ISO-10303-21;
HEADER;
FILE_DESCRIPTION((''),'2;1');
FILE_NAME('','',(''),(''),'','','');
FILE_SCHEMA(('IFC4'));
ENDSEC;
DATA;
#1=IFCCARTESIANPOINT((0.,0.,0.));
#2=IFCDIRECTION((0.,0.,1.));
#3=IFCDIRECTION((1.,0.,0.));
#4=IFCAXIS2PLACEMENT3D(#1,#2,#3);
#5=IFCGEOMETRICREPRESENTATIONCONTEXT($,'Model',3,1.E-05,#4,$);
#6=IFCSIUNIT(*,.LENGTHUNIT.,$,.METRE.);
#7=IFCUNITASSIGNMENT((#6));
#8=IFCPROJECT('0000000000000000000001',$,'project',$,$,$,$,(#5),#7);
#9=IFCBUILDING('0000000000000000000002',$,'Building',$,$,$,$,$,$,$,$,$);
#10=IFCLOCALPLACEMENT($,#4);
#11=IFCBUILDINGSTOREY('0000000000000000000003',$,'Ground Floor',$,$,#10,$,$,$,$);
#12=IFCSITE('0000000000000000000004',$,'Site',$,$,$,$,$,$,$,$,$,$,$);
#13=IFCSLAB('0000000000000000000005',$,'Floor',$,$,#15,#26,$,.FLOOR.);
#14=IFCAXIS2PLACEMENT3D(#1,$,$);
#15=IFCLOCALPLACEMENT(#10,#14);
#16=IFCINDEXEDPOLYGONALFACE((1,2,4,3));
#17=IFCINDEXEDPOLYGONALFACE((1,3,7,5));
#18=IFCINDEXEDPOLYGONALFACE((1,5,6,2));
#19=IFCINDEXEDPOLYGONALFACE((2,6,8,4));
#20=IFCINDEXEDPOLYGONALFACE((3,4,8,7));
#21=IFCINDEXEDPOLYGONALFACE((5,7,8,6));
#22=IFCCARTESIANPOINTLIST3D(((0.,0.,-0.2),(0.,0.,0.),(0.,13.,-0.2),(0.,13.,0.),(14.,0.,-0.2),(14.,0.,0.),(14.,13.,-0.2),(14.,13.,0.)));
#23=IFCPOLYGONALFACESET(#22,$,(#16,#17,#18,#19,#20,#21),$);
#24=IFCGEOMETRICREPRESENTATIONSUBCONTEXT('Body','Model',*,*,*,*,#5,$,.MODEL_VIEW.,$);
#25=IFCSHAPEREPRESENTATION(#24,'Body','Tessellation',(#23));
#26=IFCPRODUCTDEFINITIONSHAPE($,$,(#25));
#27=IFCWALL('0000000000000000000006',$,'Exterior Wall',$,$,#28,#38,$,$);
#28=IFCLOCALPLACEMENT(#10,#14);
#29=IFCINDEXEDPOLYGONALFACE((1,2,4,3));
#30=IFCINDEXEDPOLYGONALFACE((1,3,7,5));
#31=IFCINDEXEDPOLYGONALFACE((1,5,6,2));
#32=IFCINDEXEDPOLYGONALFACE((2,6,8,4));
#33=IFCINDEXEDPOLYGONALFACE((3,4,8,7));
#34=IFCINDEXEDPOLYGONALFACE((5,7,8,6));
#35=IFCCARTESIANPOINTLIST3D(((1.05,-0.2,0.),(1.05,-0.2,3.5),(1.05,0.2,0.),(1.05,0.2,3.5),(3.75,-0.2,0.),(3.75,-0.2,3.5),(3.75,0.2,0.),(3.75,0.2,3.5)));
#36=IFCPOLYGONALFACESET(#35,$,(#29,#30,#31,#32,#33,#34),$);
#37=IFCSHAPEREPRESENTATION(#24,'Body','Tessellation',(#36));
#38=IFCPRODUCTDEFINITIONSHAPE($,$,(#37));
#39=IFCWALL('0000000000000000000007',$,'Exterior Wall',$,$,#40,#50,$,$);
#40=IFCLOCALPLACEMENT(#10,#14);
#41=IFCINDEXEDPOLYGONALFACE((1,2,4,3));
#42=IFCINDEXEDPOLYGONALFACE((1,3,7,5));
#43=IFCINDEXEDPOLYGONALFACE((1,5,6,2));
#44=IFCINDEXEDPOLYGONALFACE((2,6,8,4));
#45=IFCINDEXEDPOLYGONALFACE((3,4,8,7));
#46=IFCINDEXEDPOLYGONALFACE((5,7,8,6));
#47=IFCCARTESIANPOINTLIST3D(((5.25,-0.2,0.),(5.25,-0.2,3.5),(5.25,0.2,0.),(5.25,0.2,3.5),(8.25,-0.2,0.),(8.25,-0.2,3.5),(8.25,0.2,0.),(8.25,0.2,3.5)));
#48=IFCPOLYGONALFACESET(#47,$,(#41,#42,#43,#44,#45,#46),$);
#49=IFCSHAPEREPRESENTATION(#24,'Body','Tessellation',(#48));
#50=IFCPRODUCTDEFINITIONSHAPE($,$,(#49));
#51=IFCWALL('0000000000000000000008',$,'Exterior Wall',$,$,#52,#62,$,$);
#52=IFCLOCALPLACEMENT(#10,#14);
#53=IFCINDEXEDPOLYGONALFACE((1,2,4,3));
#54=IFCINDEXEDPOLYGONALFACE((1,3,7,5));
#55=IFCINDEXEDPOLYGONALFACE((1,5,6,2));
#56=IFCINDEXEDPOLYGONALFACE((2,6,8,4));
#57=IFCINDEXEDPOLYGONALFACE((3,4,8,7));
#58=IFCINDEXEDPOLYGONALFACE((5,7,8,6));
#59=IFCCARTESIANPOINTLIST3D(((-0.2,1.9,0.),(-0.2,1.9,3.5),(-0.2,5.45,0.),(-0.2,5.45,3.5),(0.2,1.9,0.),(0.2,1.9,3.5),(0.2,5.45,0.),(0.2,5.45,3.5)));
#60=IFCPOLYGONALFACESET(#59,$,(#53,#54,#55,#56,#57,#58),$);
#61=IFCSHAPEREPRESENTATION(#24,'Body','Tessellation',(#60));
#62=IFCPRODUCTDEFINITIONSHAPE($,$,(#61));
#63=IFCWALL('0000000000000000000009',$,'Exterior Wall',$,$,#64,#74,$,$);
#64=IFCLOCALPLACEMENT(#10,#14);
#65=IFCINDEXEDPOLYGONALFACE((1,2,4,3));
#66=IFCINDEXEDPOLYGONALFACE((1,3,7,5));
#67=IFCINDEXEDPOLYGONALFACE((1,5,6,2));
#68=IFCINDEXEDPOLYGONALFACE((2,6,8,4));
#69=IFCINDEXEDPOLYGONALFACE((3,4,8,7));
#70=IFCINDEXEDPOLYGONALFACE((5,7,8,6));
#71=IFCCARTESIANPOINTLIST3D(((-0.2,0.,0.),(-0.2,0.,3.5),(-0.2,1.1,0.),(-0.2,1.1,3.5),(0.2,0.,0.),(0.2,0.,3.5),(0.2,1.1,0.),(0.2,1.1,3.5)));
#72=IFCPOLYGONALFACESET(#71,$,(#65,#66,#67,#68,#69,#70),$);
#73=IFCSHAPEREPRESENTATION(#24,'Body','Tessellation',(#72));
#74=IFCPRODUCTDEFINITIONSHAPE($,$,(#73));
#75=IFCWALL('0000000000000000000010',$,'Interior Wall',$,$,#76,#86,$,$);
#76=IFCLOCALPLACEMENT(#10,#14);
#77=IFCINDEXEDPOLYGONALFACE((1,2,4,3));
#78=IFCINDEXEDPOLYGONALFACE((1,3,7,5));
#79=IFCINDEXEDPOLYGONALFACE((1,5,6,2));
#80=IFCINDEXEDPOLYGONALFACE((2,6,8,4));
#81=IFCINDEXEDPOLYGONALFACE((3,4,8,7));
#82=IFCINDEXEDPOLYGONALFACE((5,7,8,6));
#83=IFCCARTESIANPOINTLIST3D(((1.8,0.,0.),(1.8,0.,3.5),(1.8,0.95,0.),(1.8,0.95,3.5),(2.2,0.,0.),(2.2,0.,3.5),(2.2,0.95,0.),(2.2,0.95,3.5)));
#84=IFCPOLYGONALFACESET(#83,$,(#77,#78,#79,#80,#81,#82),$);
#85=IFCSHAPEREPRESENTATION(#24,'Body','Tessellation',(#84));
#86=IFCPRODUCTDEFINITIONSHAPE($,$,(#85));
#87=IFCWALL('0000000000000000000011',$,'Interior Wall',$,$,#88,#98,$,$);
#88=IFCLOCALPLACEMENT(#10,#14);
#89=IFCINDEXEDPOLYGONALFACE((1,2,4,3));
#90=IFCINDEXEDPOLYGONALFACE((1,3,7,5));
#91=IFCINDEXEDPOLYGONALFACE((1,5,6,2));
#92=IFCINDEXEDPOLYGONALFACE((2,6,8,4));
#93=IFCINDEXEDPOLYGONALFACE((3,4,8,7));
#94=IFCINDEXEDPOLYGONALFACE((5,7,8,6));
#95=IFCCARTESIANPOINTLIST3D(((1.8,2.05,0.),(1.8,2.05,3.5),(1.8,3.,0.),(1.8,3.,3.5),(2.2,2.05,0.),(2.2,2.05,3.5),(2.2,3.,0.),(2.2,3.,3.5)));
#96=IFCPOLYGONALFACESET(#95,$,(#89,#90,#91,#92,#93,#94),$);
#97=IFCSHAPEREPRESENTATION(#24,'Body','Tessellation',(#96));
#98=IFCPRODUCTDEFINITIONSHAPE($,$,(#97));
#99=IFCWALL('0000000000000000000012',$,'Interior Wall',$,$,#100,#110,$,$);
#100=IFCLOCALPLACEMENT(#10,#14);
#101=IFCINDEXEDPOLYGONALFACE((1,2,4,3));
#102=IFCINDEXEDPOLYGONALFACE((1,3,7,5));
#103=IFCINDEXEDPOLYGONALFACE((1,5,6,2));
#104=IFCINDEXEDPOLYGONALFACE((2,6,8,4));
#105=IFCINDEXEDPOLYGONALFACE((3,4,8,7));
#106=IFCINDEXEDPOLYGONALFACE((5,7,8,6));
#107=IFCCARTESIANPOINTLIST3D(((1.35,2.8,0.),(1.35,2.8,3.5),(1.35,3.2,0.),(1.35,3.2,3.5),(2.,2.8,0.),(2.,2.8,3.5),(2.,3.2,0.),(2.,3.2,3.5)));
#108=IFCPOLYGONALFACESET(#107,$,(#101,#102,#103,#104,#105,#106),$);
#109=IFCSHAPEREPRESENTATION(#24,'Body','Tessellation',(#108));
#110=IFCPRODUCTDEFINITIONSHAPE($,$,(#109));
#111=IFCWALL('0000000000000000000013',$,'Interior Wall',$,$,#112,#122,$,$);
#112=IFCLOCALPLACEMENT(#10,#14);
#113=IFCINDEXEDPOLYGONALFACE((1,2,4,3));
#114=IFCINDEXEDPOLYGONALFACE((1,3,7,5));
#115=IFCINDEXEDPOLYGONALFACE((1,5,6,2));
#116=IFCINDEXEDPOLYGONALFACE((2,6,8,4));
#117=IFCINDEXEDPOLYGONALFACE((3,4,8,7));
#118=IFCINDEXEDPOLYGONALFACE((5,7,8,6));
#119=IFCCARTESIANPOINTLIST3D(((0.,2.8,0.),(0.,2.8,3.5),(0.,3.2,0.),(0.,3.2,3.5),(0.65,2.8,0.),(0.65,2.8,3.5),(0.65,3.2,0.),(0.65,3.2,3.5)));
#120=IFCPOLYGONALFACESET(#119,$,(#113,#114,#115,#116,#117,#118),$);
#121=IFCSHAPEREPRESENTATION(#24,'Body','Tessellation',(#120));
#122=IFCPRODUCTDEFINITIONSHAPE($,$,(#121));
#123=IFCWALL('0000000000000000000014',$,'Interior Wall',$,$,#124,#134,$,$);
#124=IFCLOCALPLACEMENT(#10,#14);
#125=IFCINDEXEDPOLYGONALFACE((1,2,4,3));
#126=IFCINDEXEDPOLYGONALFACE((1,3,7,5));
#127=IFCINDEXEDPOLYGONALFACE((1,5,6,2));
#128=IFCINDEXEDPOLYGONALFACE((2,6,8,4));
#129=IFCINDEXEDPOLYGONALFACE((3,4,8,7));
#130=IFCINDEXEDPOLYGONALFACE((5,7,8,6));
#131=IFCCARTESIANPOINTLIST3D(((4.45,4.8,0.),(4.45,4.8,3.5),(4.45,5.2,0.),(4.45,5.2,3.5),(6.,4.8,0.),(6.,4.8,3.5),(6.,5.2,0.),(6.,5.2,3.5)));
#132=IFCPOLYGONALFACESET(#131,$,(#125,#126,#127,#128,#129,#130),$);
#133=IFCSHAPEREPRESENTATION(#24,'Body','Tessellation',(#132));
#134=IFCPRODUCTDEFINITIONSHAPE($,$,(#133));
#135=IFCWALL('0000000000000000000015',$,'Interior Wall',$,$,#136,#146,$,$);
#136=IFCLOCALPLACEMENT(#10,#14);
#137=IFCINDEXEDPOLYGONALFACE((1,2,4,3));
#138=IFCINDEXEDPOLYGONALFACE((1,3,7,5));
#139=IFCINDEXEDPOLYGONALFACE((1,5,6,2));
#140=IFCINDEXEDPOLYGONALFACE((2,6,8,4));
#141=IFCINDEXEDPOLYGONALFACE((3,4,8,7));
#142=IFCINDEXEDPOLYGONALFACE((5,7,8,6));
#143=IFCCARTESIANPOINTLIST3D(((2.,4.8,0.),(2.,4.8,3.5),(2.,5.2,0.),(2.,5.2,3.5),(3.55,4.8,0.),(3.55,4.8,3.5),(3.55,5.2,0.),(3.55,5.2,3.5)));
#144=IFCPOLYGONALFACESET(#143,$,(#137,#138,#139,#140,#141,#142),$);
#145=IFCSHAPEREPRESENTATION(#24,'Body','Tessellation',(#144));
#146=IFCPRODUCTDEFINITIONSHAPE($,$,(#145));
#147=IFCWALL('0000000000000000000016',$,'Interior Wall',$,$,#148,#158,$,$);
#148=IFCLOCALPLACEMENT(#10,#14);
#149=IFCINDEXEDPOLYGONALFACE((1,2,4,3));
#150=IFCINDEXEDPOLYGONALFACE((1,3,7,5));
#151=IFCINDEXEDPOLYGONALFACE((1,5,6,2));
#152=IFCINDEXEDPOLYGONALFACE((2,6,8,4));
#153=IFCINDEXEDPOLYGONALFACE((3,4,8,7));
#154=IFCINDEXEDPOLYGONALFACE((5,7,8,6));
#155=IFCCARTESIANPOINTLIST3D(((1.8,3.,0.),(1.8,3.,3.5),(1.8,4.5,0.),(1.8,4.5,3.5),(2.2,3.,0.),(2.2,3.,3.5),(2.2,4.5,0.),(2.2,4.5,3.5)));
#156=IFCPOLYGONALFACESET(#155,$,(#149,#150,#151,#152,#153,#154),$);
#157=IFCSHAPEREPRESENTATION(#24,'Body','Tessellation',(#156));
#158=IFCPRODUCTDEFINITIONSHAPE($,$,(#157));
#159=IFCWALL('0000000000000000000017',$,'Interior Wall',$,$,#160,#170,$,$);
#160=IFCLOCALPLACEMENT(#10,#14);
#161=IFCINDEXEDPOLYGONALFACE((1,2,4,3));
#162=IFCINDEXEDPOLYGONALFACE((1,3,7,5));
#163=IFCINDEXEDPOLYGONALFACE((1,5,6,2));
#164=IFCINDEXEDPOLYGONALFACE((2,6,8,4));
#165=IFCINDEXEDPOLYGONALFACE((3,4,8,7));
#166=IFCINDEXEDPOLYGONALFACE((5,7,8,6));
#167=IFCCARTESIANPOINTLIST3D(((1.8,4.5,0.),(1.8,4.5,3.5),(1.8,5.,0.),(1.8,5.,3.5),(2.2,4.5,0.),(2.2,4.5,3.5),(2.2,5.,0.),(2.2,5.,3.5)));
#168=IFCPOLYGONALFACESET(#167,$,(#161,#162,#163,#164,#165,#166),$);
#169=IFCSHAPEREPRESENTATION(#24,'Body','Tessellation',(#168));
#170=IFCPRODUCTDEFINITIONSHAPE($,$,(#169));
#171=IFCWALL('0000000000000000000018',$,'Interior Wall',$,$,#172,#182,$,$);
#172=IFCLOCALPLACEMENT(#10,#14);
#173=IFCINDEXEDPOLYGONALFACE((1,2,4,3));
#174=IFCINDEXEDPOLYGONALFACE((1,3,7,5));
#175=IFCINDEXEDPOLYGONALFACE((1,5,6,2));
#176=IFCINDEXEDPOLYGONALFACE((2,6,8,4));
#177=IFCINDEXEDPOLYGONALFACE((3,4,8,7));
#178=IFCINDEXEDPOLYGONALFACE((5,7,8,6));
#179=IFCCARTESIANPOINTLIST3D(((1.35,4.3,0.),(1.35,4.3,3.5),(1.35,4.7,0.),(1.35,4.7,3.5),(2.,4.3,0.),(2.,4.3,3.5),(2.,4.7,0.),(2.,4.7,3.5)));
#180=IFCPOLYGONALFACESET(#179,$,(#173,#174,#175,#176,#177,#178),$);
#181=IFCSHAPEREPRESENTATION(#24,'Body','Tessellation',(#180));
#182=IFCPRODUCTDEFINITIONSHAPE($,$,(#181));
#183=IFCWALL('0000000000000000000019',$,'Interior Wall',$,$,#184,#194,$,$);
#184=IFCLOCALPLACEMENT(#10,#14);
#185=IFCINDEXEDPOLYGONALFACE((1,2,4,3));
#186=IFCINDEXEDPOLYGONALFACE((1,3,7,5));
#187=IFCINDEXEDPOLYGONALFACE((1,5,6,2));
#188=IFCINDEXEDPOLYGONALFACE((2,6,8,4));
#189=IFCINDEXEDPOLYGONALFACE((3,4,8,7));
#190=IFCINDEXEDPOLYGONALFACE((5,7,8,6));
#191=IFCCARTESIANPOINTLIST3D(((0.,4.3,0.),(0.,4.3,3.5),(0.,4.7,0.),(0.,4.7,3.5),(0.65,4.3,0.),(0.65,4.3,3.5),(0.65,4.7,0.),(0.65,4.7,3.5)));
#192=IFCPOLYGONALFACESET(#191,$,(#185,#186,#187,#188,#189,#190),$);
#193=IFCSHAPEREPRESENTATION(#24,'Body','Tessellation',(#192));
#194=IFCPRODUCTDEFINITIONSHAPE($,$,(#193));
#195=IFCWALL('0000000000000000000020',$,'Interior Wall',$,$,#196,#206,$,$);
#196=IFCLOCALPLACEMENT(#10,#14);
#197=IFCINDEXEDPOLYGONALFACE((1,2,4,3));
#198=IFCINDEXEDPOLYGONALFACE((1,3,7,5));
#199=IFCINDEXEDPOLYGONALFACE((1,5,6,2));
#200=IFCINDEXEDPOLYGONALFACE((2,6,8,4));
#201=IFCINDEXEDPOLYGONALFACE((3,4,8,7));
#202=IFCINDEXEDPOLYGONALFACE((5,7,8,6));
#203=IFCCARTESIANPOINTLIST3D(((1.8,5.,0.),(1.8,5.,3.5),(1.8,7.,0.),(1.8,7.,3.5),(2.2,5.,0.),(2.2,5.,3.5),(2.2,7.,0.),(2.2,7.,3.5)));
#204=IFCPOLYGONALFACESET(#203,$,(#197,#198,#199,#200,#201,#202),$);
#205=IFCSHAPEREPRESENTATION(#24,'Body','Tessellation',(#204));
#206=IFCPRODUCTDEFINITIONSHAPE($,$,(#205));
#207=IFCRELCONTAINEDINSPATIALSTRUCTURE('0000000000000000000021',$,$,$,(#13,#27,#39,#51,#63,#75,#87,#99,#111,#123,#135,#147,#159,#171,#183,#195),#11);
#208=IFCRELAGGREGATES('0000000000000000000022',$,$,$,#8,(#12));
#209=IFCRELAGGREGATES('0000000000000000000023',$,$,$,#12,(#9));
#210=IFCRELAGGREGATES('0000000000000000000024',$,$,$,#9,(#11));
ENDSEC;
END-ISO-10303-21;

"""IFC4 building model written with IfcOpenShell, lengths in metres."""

from ifc_helpers import new_model, si_unit, frame, origin_with_axes, place, context, subcontext, project, spatial, indexed_curve, outline, extrude, element, save


model = new_model("IFC4")

# Units and contexts
model_context = context("Model", 3, precision=1e-05, world=origin_with_axes())
body_context = subcontext(model_context, "Body", "Model", "MODEL_VIEW")
ifc_project = project(units=[si_unit("LENGTHUNIT", "METRE")], contexts=[model_context])

# Site, building, storey
site = spatial("IfcSite", under=ifc_project, Name="Site")
building = spatial("IfcBuilding", under=site, Name="Building")
storey_placement = place(None, origin_with_axes())
storey = spatial("IfcBuildingStorey", under=building, at=storey_placement, Name="Ground Floor")

# Slab
slab_placement = place(storey_placement, frame((0.0, 0.0, -0.2), z_axis=(0.0, 0.0, 1.0), x_axis=(1.0, 0.0, 0.0)))
element("IfcSlab", 1, at=slab_placement, inside=storey, Name="Floor", PredefinedType="FLOOR", context=body_context, shape_type="SweptSolid", body=[
    extrude(outline(indexed_curve([(0.0, 0.0), (14.0, 0.0), (14.0, 13.0), (0.0, 13.0)])), None, (0.0, 0.0, 1.0), 0.2),
])

# Walls
wall_1_placement = place(storey_placement, frame((1.05, 0.0, 0.0), z_axis=(0.0, 0.0, 1.0), x_axis=(1.0, 0.0, 0.0)))
element("IfcWall", 2, at=wall_1_placement, inside=storey, Name="Exterior Wall", context=body_context, shape_type="SweptSolid", body=[
    extrude(outline(indexed_curve([(0.0, 0.0), (0.0, 0.4), (2.7, 0.4), (2.7, 0.0), (0.0, 0.0)], self_intersect=False)), frame((0.0, -0.2, 0.0), z_axis=(0.0, 0.0, 1.0), x_axis=(1.0, 0.0, 0.0)), (0.0, 0.0, 1.0), 3.5),
])
wall_2_placement = place(storey_placement, frame((5.25, 0.0, 0.0), z_axis=(0.0, 0.0, 1.0), x_axis=(1.0, 0.0, 0.0)))
element("IfcWall", 3, at=wall_2_placement, inside=storey, Name="Exterior Wall", context=body_context, shape_type="SweptSolid", body=[
    extrude(outline(indexed_curve([(0.0, 0.0), (0.0, 0.4), (3.0, 0.4), (3.0, 0.0), (0.0, 0.0)], self_intersect=False)), frame((0.0, -0.2, 0.0), z_axis=(0.0, 0.0, 1.0), x_axis=(1.0, 0.0, 0.0)), (0.0, 0.0, 1.0), 3.5),
])
wall_3_placement = place(storey_placement, frame((0.0, 5.45, 0.0), z_axis=(0.0, 0.0, 1.0), x_axis=(0.0, -1.0, 0.0)))
element("IfcWall", 4, at=wall_3_placement, inside=storey, Name="Exterior Wall", context=body_context, shape_type="SweptSolid", body=[
    extrude(outline(indexed_curve([(0.0, 0.0), (0.0, 0.4), (3.55, 0.4), (3.55, 0.0), (0.0, 0.0)], self_intersect=False)), frame((0.0, -0.2, 0.0), z_axis=(0.0, 0.0, 1.0), x_axis=(1.0, 0.0, 0.0)), (0.0, 0.0, 1.0), 3.5),
])
wall_4_placement = place(storey_placement, frame((0.0, 1.1, 0.0), z_axis=(0.0, 0.0, 1.0), x_axis=(0.0, -1.0, 0.0)))
element("IfcWall", 5, at=wall_4_placement, inside=storey, Name="Exterior Wall", context=body_context, shape_type="SweptSolid", body=[
    extrude(outline(indexed_curve([(0.0, 0.0), (0.0, 0.4), (1.1, 0.4), (1.1, 0.0), (0.0, 0.0)], self_intersect=False)), frame((0.0, -0.2, 0.0), z_axis=(0.0, 0.0, 1.0), x_axis=(1.0, 0.0, 0.0)), (0.0, 0.0, 1.0), 3.5),
])
wall_5_placement = place(storey_placement, frame((2.0, 0.0, 0.0), z_axis=(0.0, 0.0, 1.0), x_axis=(0.0, 1.0, 0.0)))
element("IfcWall", 6, at=wall_5_placement, inside=storey, Name="Interior Wall", context=body_context, shape_type="SweptSolid", body=[
    extrude(outline(indexed_curve([(0.0, 0.0), (0.0, 0.4), (0.95, 0.4), (0.95, 0.0), (0.0, 0.0)], self_intersect=False)), frame((0.0, -0.2, 0.0), z_axis=(0.0, 0.0, 1.0), x_axis=(1.0, 0.0, 0.0)), (0.0, 0.0, 1.0), 3.5),
])
wall_6_placement = place(storey_placement, frame((2.0, 2.05, 0.0), z_axis=(0.0, 0.0, 1.0), x_axis=(0.0, 1.0, 0.0)))
element("IfcWall", 7, at=wall_6_placement, inside=storey, Name="Interior Wall", context=body_context, shape_type="SweptSolid", body=[
    extrude(outline(indexed_curve([(0.0, 0.0), (0.0, 0.4), (0.95, 0.4), (0.95, 0.0), (0.0, 0.0)], self_intersect=False)), frame((0.0, -0.2, 0.0), z_axis=(0.0, 0.0, 1.0), x_axis=(1.0, 0.0, 0.0)), (0.0, 0.0, 1.0), 3.5),
])
for number, where, z_axis, x_axis, name in (
    (8, (2.0, 3.0, 0.0), (0.0, 0.0, 1.0), (-1.0, 0.0, 0.0), "Interior Wall"),
    (9, (0.65, 3.0, 0.0), (0.0, 0.0, 1.0), (-1.0, 0.0, 0.0), "Interior Wall"),
):
    element("IfcWall", number, at=place(storey_placement, frame(where, z_axis=z_axis, x_axis=x_axis)), inside=storey, Name=name, context=body_context, shape_type="SweptSolid", body=[
        extrude(outline(indexed_curve([(0.0, 0.0), (0.0, 0.4), (0.65, 0.4), (0.65, 0.0), (0.0, 0.0)], self_intersect=False)), frame((0.0, -0.2, 0.0), z_axis=(0.0, 0.0, 1.0), x_axis=(1.0, 0.0, 0.0)), (0.0, 0.0, 1.0), 3.5),
    ])
for number, where, z_axis, x_axis, name in (
    (10, (6.0, 5.0, 0.0), (0.0, 0.0, 1.0), (-1.0, 0.0, 0.0), "Interior Wall"),
    (11, (3.55, 5.0, 0.0), (0.0, 0.0, 1.0), (-1.0, 0.0, 0.0), "Interior Wall"),
):
    element("IfcWall", number, at=place(storey_placement, frame(where, z_axis=z_axis, x_axis=x_axis)), inside=storey, Name=name, context=body_context, shape_type="SweptSolid", body=[
        extrude(outline(indexed_curve([(0.0, 0.0), (0.0, 0.4), (1.55, 0.4), (1.55, 0.0), (0.0, 0.0)], self_intersect=False)), frame((0.0, -0.2, 0.0), z_axis=(0.0, 0.0, 1.0), x_axis=(1.0, 0.0, 0.0)), (0.0, 0.0, 1.0), 3.5),
    ])
wall_7_placement = place(storey_placement, frame((2.0, 4.5, 0.0), z_axis=(0.0, 0.0, 1.0), x_axis=(0.0, -1.0, 0.0)))
element("IfcWall", 12, at=wall_7_placement, inside=storey, Name="Interior Wall", context=body_context, shape_type="SweptSolid", body=[
    extrude(outline(indexed_curve([(0.0, 0.0), (0.0, 0.4), (1.5, 0.4), (1.5, 0.0), (0.0, 0.0)], self_intersect=False)), frame((0.0, -0.2, 0.0), z_axis=(0.0, 0.0, 1.0), x_axis=(1.0, 0.0, 0.0)), (0.0, 0.0, 1.0), 3.5),
])
wall_8_placement = place(storey_placement, frame((2.0, 5.0, 0.0), z_axis=(0.0, 0.0, 1.0), x_axis=(0.0, -1.0, 0.0)))
element("IfcWall", 13, at=wall_8_placement, inside=storey, Name="Interior Wall", context=body_context, shape_type="SweptSolid", body=[
    extrude(outline(indexed_curve([(0.0, 0.0), (0.0, 0.4), (0.5, 0.4), (0.5, 0.0), (0.0, 0.0)], self_intersect=False)), frame((0.0, -0.2, 0.0), z_axis=(0.0, 0.0, 1.0), x_axis=(1.0, 0.0, 0.0)), (0.0, 0.0, 1.0), 3.5),
])
for number, where, z_axis, x_axis, name in (
    (14, (2.0, 4.5, 0.0), (0.0, 0.0, 1.0), (-1.0, 0.0, 0.0), "Interior Wall"),
    (15, (0.65, 4.5, 0.0), (0.0, 0.0, 1.0), (-1.0, 0.0, 0.0), "Interior Wall"),
):
    element("IfcWall", number, at=place(storey_placement, frame(where, z_axis=z_axis, x_axis=x_axis)), inside=storey, Name=name, context=body_context, shape_type="SweptSolid", body=[
        extrude(outline(indexed_curve([(0.0, 0.0), (0.0, 0.4), (0.65, 0.4), (0.65, 0.0), (0.0, 0.0)], self_intersect=False)), frame((0.0, -0.2, 0.0), z_axis=(0.0, 0.0, 1.0), x_axis=(1.0, 0.0, 0.0)), (0.0, 0.0, 1.0), 3.5),
    ])
wall_9_placement = place(storey_placement, frame((2.0, 5.0, 0.0), z_axis=(0.0, 0.0, 1.0), x_axis=(0.0, 1.0, 0.0)))
element("IfcWall", 16, at=wall_9_placement, inside=storey, Name="Interior Wall", context=body_context, shape_type="SweptSolid", body=[
    extrude(outline(indexed_curve([(0.0, 0.0), (0.0, 0.4), (2.0, 0.4), (2.0, 0.0), (0.0, 0.0)], self_intersect=False)), frame((0.0, -0.2, 0.0), z_axis=(0.0, 0.0, 1.0), x_axis=(1.0, 0.0, 0.0)), (0.0, 0.0, 1.0), 3.5),
])

save(model, "model.ifc")
